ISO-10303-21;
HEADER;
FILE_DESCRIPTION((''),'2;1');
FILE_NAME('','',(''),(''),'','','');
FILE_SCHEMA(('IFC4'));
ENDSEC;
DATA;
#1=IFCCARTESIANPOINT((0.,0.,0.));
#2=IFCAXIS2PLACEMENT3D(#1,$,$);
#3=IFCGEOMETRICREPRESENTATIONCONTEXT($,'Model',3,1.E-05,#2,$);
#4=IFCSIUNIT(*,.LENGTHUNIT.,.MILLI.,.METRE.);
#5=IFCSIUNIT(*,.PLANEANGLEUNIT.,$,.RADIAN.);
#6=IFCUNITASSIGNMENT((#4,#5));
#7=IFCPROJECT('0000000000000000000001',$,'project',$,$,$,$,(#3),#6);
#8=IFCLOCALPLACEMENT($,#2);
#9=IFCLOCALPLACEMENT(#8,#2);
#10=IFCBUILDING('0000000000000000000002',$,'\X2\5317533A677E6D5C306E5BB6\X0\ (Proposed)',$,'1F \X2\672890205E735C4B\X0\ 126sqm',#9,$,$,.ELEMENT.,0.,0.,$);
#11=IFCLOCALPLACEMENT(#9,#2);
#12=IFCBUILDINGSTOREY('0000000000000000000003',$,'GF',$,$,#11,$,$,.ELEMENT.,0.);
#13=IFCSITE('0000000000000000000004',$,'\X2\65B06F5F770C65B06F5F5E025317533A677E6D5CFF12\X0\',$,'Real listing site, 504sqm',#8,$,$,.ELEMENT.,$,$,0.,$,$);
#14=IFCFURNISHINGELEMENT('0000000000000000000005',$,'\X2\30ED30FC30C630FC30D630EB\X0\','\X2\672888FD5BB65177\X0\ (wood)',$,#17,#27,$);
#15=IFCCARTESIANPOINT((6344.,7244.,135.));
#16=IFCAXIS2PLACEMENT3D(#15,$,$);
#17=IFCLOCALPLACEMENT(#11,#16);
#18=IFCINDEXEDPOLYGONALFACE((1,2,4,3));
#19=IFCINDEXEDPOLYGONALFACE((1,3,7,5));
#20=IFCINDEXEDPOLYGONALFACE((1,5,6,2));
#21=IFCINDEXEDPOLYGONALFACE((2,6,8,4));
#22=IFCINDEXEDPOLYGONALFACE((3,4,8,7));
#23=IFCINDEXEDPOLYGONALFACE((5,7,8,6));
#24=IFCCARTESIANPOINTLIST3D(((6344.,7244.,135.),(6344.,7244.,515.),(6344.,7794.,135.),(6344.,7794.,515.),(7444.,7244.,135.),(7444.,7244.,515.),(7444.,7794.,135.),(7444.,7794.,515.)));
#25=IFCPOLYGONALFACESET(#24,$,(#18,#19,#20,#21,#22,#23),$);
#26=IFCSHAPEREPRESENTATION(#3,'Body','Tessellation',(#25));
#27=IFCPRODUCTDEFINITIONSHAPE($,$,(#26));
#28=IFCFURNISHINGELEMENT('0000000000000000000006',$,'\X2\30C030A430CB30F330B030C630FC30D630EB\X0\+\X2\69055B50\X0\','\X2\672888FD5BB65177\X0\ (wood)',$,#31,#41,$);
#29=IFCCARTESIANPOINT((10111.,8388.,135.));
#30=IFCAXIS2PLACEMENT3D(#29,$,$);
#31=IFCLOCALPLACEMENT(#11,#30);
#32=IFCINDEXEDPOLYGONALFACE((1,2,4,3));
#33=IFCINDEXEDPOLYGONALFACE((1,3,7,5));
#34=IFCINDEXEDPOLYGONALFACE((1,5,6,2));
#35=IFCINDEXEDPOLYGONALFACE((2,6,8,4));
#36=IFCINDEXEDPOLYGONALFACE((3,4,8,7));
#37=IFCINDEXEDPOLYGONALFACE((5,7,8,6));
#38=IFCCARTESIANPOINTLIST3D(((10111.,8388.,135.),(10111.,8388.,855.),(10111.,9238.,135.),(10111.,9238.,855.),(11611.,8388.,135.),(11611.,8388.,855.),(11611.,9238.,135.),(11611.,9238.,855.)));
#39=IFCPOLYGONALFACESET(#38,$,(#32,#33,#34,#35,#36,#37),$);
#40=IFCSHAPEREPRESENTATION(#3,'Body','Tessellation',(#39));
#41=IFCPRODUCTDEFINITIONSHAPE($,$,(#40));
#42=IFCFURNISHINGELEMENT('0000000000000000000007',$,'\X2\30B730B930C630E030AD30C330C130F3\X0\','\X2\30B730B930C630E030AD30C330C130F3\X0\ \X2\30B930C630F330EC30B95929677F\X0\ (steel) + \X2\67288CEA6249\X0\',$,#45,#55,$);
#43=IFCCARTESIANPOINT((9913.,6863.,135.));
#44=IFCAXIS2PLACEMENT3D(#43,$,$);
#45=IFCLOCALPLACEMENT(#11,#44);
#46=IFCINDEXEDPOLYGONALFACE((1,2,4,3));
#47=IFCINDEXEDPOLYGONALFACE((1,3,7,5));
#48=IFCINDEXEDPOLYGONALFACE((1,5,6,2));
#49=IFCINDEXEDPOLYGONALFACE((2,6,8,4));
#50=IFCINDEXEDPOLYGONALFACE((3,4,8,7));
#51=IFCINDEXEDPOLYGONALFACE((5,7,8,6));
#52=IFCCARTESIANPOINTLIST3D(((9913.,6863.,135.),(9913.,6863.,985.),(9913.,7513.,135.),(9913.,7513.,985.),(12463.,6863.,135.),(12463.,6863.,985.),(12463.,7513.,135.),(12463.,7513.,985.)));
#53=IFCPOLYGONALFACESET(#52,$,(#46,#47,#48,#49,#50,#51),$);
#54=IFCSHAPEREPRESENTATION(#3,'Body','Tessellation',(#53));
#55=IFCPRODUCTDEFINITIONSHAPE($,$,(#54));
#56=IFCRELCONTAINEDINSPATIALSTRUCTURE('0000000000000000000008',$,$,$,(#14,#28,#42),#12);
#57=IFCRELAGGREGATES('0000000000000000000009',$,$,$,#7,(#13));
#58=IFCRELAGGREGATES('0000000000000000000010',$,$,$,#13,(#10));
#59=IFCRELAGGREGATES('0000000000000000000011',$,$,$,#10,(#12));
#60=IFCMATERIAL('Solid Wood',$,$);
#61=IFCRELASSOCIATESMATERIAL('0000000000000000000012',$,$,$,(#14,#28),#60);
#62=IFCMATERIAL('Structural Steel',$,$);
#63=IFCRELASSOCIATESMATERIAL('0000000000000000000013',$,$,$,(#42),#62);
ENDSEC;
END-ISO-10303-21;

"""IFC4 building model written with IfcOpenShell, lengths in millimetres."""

from ifc_helpers import new_model, si_unit, frame, frame_2d, origin, place, context, project, spatial, rectangle, extrude, material, element, save


model = new_model("IFC4")

# Units and contexts
model_context = context("Model", 3, precision=1e-05, world=origin())
ifc_project = project(units=[si_unit("LENGTHUNIT", "METRE", prefix="MILLI"), si_unit("PLANEANGLEUNIT", "RADIAN")], contexts=[model_context])

# Site, building, storey
site_placement = place(None, origin())
site = spatial("IfcSite", under=ifc_project, at=site_placement, Name="新潟県新潟市北区松浜２", ObjectType="Real listing site, 504sqm", CompositionType="ELEMENT", RefElevation=0.0)
building_placement = place(site_placement, origin())
building = spatial("IfcBuilding", under=site, at=building_placement, Name="北区松浜の家 (Proposed)", ObjectType="1F 木造平屋 126sqm", CompositionType="ELEMENT", ElevationOfRefHeight=0.0, ElevationOfTerrain=0.0)
storey_placement = place(building_placement, origin())
storey = spatial("IfcBuildingStorey", under=building, at=storey_placement, Name="GF", CompositionType="ELEMENT", Elevation=0.0)

# Shared definitions
ifc_material_1 = material(Name="Solid Wood")

# Shared definitions
ifc_material_2 = material(Name="Structural Steel")

# Furnishing elements
furnishing_1_placement = place(storey_placement, frame((6344.0, 7244.0, 135.0)))
element("IfcFurnishingElement", 1, at=furnishing_1_placement, inside=storey, material=ifc_material_1, Name="ローテーブル", Description="木製家具 (wood)", context=model_context, shape_type="SweptSolid", body=[
    extrude(rectangle(XDim=1100.0, YDim=550.0, at=frame_2d((550.0, 275.0))), frame((6344.0, 7244.0, 135.0)), (0.0, 0.0, 1.0), 380.0),
])
furnishing_2_placement = place(storey_placement, frame((10111.0, 8388.0, 135.0)))
element("IfcFurnishingElement", 2, at=furnishing_2_placement, inside=storey, material=ifc_material_1, Name="ダイニングテーブル+椅子", Description="木製家具 (wood)", context=model_context, shape_type="SweptSolid", body=[
    extrude(rectangle(XDim=1500.0, YDim=850.0, at=frame_2d((750.0, 425.0))), frame((10111.0, 8388.0, 135.0)), (0.0, 0.0, 1.0), 720.0),
])
furnishing_3_placement = place(storey_placement, frame((9913.0, 6863.0, 135.0)))
element("IfcFurnishingElement", 3, at=furnishing_3_placement, inside=storey, material=ifc_material_2, Name="システムキッチン", Description="システムキッチン ステンレス天板 (steel) + 木質扉", context=model_context, shape_type="SweptSolid", body=[
    extrude(rectangle(XDim=2550.0, YDim=650.0, at=frame_2d((1275.0, 325.0))), frame((9913.0, 6863.0, 135.0)), (0.0, 0.0, 1.0), 850.0),
])

save(model, "model.ifc")
